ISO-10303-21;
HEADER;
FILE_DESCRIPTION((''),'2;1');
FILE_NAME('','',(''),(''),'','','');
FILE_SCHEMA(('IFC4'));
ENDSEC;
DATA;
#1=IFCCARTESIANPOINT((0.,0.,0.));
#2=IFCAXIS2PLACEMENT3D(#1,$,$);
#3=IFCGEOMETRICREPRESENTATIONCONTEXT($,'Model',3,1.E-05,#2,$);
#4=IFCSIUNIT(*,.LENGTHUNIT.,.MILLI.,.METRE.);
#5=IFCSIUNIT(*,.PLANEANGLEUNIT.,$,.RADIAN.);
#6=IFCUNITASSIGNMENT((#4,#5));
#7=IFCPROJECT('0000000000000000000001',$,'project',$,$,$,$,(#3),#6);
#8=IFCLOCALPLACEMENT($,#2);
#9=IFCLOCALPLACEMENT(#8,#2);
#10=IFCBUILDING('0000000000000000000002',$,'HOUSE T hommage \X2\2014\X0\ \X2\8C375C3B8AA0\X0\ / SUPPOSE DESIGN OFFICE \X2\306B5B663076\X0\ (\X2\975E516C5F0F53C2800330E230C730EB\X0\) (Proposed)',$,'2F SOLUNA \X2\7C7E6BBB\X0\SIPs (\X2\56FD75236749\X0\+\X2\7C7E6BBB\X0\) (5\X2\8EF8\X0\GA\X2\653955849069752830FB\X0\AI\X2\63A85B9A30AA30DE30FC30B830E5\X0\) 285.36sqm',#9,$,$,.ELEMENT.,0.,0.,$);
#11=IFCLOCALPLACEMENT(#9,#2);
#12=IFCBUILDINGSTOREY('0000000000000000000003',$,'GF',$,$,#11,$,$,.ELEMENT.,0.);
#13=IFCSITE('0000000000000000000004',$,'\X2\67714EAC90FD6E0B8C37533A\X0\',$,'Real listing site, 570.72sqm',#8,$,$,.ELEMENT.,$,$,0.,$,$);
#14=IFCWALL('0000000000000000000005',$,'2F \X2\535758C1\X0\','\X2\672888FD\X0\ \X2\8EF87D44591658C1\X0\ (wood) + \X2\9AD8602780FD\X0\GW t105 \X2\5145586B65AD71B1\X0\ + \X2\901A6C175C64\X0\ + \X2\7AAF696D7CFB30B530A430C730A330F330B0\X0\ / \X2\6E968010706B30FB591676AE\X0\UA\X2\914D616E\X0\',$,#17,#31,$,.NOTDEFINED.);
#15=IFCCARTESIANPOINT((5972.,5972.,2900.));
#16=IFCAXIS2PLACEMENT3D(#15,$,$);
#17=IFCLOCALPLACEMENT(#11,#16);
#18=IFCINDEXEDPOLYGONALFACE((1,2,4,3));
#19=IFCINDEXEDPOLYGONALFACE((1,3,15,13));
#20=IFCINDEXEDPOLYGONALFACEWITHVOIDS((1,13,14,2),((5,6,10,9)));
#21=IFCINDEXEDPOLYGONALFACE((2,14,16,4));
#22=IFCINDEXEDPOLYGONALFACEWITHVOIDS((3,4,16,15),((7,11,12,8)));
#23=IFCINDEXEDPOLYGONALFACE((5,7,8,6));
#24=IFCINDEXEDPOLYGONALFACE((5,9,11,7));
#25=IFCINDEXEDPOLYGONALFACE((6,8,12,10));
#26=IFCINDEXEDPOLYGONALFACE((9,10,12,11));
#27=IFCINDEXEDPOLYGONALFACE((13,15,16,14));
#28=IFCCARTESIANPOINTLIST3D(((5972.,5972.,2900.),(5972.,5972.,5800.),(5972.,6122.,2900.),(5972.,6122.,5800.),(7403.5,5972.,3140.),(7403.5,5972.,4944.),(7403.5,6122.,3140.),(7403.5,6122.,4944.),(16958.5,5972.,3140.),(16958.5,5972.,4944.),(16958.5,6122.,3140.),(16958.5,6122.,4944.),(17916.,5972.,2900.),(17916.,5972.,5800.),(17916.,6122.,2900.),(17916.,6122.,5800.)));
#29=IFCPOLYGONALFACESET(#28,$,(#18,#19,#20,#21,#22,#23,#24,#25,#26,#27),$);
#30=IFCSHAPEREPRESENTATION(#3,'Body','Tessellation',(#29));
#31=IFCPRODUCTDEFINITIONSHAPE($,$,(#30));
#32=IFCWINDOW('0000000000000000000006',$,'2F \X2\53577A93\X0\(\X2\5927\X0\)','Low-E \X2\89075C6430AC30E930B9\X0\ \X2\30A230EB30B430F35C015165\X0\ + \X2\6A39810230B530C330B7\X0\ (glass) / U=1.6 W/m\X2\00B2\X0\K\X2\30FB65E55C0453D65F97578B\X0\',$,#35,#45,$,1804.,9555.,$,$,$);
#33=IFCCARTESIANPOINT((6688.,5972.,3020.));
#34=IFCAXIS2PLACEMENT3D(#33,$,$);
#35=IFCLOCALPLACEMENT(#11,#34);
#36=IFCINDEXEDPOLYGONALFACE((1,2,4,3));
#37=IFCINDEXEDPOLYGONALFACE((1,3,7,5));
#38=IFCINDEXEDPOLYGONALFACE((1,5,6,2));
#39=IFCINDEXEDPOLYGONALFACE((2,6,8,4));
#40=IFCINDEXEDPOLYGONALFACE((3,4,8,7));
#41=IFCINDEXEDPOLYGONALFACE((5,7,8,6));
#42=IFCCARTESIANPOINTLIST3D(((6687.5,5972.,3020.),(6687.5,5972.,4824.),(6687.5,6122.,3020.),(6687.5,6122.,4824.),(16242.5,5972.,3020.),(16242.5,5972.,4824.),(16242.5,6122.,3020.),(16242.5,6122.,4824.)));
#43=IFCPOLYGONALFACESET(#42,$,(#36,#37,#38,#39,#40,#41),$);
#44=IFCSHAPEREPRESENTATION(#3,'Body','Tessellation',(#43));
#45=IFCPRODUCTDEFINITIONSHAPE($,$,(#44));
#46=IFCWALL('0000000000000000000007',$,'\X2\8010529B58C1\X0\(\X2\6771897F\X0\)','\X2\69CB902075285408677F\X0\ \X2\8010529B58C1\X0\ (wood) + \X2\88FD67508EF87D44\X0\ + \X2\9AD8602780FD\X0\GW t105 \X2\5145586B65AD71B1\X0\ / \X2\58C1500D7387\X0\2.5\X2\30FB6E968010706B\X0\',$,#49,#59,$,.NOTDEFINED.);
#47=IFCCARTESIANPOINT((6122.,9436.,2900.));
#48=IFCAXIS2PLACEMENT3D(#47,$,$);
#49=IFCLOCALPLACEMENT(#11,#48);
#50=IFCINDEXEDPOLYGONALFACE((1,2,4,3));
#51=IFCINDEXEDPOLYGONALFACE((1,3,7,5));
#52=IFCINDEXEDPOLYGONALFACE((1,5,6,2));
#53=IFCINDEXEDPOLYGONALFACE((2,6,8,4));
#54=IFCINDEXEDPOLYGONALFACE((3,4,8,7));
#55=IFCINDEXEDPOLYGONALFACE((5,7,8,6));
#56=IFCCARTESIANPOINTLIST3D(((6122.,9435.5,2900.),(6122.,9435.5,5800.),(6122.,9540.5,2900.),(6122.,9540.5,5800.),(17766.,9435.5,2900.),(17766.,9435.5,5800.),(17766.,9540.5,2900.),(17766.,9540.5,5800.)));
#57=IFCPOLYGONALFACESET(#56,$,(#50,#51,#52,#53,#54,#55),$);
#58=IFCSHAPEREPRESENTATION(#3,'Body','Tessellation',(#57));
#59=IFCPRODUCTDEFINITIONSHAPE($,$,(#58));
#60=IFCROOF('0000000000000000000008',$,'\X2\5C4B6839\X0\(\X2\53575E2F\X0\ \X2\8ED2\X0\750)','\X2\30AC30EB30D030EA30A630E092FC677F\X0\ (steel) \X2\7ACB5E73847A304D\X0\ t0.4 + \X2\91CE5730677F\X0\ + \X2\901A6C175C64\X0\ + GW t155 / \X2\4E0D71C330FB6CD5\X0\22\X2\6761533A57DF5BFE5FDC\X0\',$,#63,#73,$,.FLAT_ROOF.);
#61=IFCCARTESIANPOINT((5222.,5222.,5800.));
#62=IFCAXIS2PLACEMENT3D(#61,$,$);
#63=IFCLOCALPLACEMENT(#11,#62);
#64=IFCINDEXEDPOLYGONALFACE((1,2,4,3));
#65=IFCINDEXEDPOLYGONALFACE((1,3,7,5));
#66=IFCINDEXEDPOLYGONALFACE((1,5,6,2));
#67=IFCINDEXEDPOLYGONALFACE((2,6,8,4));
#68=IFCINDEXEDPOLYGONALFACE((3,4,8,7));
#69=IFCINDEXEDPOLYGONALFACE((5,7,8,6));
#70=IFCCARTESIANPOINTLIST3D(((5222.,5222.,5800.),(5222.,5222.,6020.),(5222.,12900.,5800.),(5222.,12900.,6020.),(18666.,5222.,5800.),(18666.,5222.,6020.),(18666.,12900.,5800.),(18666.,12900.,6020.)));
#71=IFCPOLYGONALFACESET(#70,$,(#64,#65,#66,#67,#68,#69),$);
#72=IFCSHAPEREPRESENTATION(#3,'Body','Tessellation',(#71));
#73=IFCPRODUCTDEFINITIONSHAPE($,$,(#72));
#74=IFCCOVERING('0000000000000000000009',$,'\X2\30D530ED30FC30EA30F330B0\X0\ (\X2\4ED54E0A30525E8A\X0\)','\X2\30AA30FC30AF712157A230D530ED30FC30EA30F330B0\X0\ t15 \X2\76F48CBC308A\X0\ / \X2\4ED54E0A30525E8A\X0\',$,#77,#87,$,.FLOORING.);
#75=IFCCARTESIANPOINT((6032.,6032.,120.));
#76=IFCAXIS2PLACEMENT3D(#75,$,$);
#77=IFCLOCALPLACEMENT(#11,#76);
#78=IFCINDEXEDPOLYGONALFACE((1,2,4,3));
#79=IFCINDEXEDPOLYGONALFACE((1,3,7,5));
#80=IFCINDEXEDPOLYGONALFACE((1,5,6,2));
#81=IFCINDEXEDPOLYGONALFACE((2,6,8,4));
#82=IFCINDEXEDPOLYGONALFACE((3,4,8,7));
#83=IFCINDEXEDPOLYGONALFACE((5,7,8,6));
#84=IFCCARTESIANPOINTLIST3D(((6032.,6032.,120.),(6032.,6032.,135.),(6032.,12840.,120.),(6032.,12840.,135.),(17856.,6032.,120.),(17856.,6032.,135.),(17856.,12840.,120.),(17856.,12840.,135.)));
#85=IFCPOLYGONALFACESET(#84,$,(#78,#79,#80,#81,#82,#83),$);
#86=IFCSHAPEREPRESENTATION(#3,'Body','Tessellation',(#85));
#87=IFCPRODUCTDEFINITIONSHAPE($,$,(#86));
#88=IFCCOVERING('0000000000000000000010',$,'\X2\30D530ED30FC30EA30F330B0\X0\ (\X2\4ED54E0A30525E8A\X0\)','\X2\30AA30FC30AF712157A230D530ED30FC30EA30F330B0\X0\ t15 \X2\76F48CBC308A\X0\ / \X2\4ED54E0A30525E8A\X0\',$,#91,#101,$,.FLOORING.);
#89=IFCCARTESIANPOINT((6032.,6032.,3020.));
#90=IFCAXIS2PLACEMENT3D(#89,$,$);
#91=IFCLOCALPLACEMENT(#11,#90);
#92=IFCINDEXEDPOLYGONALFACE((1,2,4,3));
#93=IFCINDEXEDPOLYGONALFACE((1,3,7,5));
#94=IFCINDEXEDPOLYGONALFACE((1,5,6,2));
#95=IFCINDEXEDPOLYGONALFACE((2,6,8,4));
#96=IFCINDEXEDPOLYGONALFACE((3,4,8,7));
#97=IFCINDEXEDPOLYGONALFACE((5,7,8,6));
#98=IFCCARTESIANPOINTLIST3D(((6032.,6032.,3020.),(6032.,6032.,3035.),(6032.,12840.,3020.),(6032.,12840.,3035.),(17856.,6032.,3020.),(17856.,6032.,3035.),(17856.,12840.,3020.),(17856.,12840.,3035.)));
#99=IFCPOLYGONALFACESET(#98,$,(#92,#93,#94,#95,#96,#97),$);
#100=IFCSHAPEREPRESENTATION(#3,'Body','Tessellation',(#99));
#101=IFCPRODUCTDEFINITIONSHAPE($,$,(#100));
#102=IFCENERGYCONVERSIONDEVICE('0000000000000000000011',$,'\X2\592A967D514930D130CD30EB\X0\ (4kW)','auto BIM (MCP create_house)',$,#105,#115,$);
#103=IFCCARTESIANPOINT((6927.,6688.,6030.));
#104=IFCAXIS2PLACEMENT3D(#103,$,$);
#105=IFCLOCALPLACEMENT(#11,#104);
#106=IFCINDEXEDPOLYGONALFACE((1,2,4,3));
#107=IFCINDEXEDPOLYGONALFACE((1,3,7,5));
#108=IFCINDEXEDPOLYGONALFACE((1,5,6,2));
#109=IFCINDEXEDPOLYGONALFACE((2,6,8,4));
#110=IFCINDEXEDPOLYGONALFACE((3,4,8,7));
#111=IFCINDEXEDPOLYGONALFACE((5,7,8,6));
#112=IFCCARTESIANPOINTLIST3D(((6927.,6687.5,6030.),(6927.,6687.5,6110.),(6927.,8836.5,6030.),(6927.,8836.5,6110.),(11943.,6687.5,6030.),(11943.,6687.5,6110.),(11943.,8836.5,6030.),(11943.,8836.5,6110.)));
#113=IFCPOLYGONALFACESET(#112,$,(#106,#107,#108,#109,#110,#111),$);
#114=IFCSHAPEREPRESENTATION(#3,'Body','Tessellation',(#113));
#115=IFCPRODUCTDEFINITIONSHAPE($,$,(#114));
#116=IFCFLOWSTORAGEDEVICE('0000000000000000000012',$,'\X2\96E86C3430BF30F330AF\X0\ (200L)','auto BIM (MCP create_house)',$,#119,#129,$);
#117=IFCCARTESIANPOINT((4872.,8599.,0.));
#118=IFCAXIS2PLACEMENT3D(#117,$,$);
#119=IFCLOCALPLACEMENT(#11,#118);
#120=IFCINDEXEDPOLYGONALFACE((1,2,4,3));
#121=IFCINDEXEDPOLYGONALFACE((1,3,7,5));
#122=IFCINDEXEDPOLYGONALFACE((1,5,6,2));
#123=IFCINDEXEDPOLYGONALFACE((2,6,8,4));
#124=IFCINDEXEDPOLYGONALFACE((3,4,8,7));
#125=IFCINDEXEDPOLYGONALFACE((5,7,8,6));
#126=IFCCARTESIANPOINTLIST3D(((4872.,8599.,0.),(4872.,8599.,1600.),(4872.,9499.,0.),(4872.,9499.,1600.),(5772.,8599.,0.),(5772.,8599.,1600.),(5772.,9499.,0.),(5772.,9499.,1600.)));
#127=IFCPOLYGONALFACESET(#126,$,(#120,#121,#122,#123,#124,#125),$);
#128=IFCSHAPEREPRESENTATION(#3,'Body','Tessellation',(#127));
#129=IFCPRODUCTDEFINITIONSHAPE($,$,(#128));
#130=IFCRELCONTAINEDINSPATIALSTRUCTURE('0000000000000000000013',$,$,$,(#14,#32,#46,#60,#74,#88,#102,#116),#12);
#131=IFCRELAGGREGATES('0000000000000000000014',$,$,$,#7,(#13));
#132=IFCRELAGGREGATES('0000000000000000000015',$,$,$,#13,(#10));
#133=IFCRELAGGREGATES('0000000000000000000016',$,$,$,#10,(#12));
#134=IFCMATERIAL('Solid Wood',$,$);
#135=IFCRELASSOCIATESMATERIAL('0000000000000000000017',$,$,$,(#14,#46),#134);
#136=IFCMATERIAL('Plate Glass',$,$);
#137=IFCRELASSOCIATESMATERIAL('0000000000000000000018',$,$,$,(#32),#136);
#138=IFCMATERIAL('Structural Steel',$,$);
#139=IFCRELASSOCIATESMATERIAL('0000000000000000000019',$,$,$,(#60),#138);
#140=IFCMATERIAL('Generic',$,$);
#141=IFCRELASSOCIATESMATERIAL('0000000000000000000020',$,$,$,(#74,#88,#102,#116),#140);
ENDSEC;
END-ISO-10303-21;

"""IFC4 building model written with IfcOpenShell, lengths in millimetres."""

from ifc_helpers import new_model, si_unit, frame, frame_2d, origin, place, context, project, spatial, rectangle, extrude, material, element, fill, save


model = new_model("IFC4")

# Units and contexts
model_context = context("Model", 3, precision=1e-05, world=origin())
ifc_project = project(units=[si_unit("LENGTHUNIT", "METRE", prefix="MILLI"), si_unit("PLANEANGLEUNIT", "RADIAN")], contexts=[model_context])

# Site, building, storey
site_placement = place(None, origin())
site = spatial("IfcSite", under=ifc_project, at=site_placement, Name="東京都渋谷区", ObjectType="Real listing site, 570.72sqm", CompositionType="ELEMENT", RefElevation=0.0)
building_placement = place(site_placement, origin())
building = spatial("IfcBuilding", under=site, at=building_placement, Name="HOUSE T hommage — 谷尻誠 / SUPPOSE DESIGN OFFICE に学ぶ (非公式参考モデル) (Proposed)", ObjectType="2F SOLUNA 籾殻SIPs (国産杉+籾殻) (5軸GA改善適用・AI推定オマージュ) 285.36sqm", CompositionType="ELEMENT", ElevationOfRefHeight=0.0, ElevationOfTerrain=0.0)
storey_placement = place(building_placement, origin())
storey = spatial("IfcBuildingStorey", under=building, at=storey_placement, Name="GF", CompositionType="ELEMENT", Elevation=0.0)

# Shared definitions
ifc_material_1 = material(Name="Solid Wood")

# Shared definitions
ifc_material_2 = material(Name="Plate Glass")

# Wall, opening, window
wall_1_placement = place(storey_placement, frame((5972.0, 5972.0, 2900.0)))
wall_1 = element("IfcWall", 1, at=wall_1_placement, inside=storey, material=ifc_material_1, Name="2F 南壁", Description="木製 軸組外壁 (wood) + 高性能GW t105 充填断熱 + 通気層 + 窯業系サイディング / 準耐火・外皮UA配慮", PredefinedType="NOTDEFINED", context=model_context, shape_type="SweptSolid", body=[
    extrude(rectangle(XDim=11944.0, YDim=150.0, at=frame_2d((5972.0, 75.0))), frame((5972.0, 5972.0, 2900.0)), (0.0, 0.0, 1.0), 2900.0),
])
opening_1_placement = place(storey_placement, frame((6688.0, 5972.0, 3020.0)))
opening_1 = element("IfcOpeningElement", 2, at=opening_1_placement, cuts=wall_1, PredefinedType="NOTDEFINED", context=model_context, shape_type="SweptSolid", body=[
    extrude(rectangle(XDim=9555.0, YDim=150.0, at=frame_2d((4777.0, 75.0))), frame((6688.0, 5972.0, 3020.0)), (0.0, 0.0, 1.0), 1804.0),
])
window_1_placement = place(storey_placement, frame((6688.0, 5972.0, 3020.0)))
window_1 = element("IfcWindow", 3, at=window_1_placement, inside=storey, material=ifc_material_2, Name="2F 南窓(大)", Description="Low-E 複層ガラス アルゴン封入 + 樹脂サッシ (glass) / U=1.6 W/m²K・日射取得型", OverallHeight=1804.0, OverallWidth=9555.0, context=model_context, shape_type="SweptSolid", body=[
    extrude(rectangle(XDim=9555.0, YDim=150.0, at=frame_2d((4777.0, 75.0))), frame((6688.0, 5972.0, 3020.0)), (0.0, 0.0, 1.0), 1804.0),
])
fill(opening_1, window_1)

# Wall
wall_2_placement = place(storey_placement, frame((6122.0, 9436.0, 2900.0)))
element("IfcWall", 4, at=wall_2_placement, inside=storey, material=ifc_material_1, Name="耐力壁(東西)", Description="構造用合板 耐力壁 (wood) + 製材軸組 + 高性能GW t105 充填断熱 / 壁倍率2.5・準耐火", PredefinedType="NOTDEFINED", context=model_context, shape_type="SweptSolid", body=[
    extrude(rectangle(XDim=11644.0, YDim=105.0, at=frame_2d((5822.0, 52.0))), frame((6122.0, 9436.0, 2900.0)), (0.0, 0.0, 1.0), 2900.0),
])

# Roof
ifc_material_3 = material(Name="Structural Steel")
for number, where, name in (
    (5, (5222.0, 5222.0, 5800.0), "屋根(南帯 軒750)"),
):
    element("IfcRoof", number, at=place(storey_placement, frame(where)), inside=storey, material=ifc_material_3, Name=name, Description="ガルバリウム鋼板 (steel) 立平葺き t0.4 + 野地板 + 通気層 + GW t155 / 不燃・法22条区域対応", PredefinedType="FLAT_ROOF", context=model_context, shape_type="SweptSolid", body=[
        extrude(rectangle(XDim=13444.0, YDim=7678.0, at=frame_2d((6722.0, 3839.0))), frame((5222.0, 5222.0, 5800.0)), (0.0, 0.0, 1.0), 220.0),
    ])

# Coverings
ifc_material_4 = material(Name="Generic")
covering_1_placement = place(storey_placement, frame((6032.0, 6032.0, 120.0)))
element("IfcCovering", 6, at=covering_1_placement, inside=storey, material=ifc_material_4, Name="フローリング (仕上げ床)", Description="オーク無垢フローリング t15 直貼り / 仕上げ床", PredefinedType="FLOORING", context=model_context, shape_type="SweptSolid", body=[
    extrude(rectangle(XDim=11824.0, YDim=6808.0, at=frame_2d((5912.0, 3404.0))), frame((6032.0, 6032.0, 120.0)), (0.0, 0.0, 1.0), 15.0),
])
covering_2_placement = place(storey_placement, frame((6032.0, 6032.0, 3020.0)))
element("IfcCovering", 7, at=covering_2_placement, inside=storey, material=ifc_material_4, Name="フローリング (仕上げ床)", Description="オーク無垢フローリング t15 直貼り / 仕上げ床", PredefinedType="FLOORING", context=model_context, shape_type="SweptSolid", body=[
    extrude(rectangle(XDim=11824.0, YDim=6808.0, at=frame_2d((5912.0, 3404.0))), frame((6032.0, 6032.0, 3020.0)), (0.0, 0.0, 1.0), 15.0),
])

# Energy conversion device
energy_conversion_device_placement = place(storey_placement, frame((6927.0, 6688.0, 6030.0)))
element("IfcEnergyConversionDevice", 8, at=energy_conversion_device_placement, inside=storey, material=ifc_material_4, Name="太陽光パネル (4kW)", Description="auto BIM (MCP create_house)", context=model_context, shape_type="SweptSolid", body=[
    extrude(rectangle(XDim=5016.0, YDim=2149.0, at=frame_2d((2508.0, 1074.0))), frame((6927.0, 6688.0, 6030.0)), (0.0, 0.0, 1.0), 80.0),
])

# Flow storage device
flow_storage_device_placement = place(storey_placement, frame((4872.0, 8599.0, 0.0)))
element("IfcFlowStorageDevice", 9, at=flow_storage_device_placement, inside=storey, material=ifc_material_4, Name="雨水タンク (200L)", Description="auto BIM (MCP create_house)", context=model_context, shape_type="SweptSolid", body=[
    extrude(rectangle(XDim=900.0, YDim=900.0, at=frame_2d((450.0, 450.0))), frame((4872.0, 8599.0, 0.0)), (0.0, 0.0, 1.0), 1600.0),
])

save(model, "model.ifc")
